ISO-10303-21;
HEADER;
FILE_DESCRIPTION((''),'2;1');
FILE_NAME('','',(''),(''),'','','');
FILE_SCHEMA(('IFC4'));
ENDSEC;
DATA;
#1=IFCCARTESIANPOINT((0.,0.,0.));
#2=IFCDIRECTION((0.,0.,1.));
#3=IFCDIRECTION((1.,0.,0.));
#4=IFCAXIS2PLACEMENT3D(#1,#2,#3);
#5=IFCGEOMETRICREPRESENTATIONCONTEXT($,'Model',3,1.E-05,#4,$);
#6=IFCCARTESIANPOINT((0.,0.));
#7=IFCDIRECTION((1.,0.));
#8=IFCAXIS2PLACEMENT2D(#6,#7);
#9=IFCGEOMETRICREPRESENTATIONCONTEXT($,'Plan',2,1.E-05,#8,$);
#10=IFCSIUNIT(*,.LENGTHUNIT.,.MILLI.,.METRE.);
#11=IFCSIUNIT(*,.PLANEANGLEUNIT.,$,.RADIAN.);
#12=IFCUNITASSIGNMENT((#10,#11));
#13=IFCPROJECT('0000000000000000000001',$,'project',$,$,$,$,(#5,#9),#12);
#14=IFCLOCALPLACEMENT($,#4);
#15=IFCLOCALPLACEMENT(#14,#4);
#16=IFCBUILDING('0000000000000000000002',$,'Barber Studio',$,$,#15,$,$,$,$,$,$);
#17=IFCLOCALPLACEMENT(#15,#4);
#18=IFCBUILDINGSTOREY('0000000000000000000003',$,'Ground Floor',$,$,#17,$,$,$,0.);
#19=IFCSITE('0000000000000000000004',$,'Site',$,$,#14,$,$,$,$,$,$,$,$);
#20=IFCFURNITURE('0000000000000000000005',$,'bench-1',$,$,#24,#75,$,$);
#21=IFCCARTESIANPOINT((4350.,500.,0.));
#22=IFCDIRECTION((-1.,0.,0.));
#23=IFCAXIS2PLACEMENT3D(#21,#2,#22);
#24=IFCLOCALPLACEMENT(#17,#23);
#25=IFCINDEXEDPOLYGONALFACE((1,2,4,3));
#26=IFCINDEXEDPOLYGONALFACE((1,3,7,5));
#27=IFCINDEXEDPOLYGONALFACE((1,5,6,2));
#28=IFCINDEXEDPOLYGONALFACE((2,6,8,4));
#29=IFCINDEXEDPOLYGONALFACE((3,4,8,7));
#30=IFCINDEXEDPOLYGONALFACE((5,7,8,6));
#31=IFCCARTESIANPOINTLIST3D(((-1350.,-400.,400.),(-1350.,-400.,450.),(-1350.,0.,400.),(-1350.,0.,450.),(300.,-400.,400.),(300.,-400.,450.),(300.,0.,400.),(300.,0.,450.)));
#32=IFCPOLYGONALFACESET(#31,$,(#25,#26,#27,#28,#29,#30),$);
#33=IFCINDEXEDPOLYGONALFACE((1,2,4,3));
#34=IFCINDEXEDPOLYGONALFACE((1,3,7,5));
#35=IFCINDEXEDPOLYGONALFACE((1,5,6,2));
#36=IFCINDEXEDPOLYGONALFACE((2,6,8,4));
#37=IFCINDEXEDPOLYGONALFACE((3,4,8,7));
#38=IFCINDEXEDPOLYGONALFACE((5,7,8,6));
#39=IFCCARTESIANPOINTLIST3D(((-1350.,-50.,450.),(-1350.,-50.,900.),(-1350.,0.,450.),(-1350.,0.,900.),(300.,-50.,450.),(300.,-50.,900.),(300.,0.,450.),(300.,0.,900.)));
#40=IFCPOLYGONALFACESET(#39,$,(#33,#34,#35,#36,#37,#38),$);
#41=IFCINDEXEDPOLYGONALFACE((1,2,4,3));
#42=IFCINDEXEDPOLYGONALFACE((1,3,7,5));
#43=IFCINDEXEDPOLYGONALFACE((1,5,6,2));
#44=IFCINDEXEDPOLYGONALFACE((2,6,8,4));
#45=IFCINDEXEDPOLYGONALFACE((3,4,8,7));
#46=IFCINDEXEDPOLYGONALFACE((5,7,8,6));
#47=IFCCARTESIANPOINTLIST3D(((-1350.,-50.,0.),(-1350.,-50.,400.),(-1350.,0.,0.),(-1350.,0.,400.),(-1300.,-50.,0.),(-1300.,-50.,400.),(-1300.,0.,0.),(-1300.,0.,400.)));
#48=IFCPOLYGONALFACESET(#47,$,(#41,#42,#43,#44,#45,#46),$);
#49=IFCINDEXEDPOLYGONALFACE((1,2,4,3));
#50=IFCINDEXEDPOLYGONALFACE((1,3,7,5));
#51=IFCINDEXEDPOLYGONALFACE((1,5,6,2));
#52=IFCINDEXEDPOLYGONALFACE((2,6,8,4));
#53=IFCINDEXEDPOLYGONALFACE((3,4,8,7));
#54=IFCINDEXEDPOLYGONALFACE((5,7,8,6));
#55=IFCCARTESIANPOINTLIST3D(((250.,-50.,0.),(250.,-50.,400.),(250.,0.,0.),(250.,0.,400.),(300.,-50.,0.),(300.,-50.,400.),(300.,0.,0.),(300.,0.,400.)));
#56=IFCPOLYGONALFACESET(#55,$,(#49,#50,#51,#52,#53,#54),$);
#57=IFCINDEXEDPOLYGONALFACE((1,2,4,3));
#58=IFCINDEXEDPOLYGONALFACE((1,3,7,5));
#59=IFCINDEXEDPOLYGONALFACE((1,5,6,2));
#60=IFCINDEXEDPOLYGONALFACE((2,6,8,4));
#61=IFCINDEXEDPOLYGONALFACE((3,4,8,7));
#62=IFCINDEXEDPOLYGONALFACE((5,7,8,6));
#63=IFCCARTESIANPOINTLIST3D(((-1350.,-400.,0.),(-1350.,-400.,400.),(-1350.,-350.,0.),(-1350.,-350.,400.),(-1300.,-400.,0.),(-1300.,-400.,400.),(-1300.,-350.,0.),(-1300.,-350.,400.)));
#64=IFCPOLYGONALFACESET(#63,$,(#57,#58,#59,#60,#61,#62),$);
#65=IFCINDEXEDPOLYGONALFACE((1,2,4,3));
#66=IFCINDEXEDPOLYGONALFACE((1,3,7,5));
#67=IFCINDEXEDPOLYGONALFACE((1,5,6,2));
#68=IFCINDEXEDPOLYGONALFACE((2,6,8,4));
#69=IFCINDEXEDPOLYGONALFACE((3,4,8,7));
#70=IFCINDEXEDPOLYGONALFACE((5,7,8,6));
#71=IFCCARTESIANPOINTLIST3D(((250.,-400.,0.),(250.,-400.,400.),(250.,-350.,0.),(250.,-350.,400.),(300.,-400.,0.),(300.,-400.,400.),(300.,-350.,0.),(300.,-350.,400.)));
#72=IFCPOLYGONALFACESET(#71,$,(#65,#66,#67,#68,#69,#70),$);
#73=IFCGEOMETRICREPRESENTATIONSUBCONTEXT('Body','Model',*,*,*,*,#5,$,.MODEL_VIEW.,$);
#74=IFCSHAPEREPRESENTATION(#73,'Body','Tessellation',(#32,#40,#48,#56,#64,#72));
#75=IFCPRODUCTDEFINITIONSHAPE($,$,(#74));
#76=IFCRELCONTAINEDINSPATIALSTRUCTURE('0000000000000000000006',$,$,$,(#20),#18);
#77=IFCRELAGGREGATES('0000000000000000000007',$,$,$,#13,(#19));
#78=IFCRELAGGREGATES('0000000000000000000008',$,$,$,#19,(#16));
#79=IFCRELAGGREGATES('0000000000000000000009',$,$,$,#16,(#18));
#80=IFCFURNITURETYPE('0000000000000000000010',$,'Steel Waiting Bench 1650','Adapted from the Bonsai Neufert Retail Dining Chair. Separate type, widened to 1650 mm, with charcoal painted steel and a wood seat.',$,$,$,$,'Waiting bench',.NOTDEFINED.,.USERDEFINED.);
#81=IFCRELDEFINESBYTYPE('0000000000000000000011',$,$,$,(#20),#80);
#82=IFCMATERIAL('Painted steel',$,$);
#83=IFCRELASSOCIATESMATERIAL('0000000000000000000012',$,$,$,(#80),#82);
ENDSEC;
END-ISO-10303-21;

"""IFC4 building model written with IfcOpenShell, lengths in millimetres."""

from ifc_helpers import new_model, entity, si_unit, frame, origin_with_axes, origin_2d_with_axis, place, context, subcontext, project, spatial, line, indexed_curve, outline, extrude, shape, source, transform, mapped, material, type_object, type_shapes, element, save


model = new_model("IFC4")

# Units and contexts
model_context = context("Model", 3, precision=1e-05, world=origin_with_axes())
plan_context = context("Plan", 2, precision=1e-05, world=origin_2d_with_axis())
body_context_1 = subcontext(model_context, "Body", "Model", "MODEL_VIEW")
body_context_2 = subcontext(plan_context, "Body", "Plan", "PLAN_VIEW")
ifc_project = project(units=[si_unit("LENGTHUNIT", "METRE", prefix="MILLI"), si_unit("PLANEANGLEUNIT", "RADIAN")], contexts=[model_context, plan_context])

# Site, building, storey
site_placement = place(None, origin_with_axes())
site = spatial("IfcSite", under=ifc_project, at=site_placement, Name="Site")
building_placement = place(site_placement, origin_with_axes())
building = spatial("IfcBuilding", under=site, at=building_placement, Name="Barber Studio")
storey_placement = place(building_placement, origin_with_axes())
storey = spatial("IfcBuildingStorey", under=building, at=storey_placement, Name="Ground Floor", Elevation=0.0)

# Shared definitions
ifc_material_1 = material(Name="Painted steel")

# Furniture
furniture_type_1 = type_object("IfcFurnitureType", Name="Steel Waiting Bench 1650", Description="Adapted from the Bonsai Neufert Retail Dining Chair. Separate type, widened to 1650 mm, with charcoal painted steel and a wood seat.", ElementType="Waiting bench", AssemblyPlace="NOTDEFINED", PredefinedType="USERDEFINED", material=ifc_material_1)
shared_shape_1 = source(origin_with_axes(), body_context_1, "Body", "SweptSolid", [
    extrude(outline(indexed_curve([(-1350.0, 0.0), (300.0, 0.0), (300.0, -400.0), (-1350.0, -400.0)], segments=[line(1, 2, 3, 4, 1)])), frame((0.0, 0.0, 450.0), z_axis=(0.0, 0.0, 1.0), x_axis=(1.0, 0.0, 0.0)), (0.0, 0.0, -1.0), 50.0),
    extrude(outline(indexed_curve([(-1350.0, 0.0), (300.0, 0.0), (300.0, -50.0), (-1350.0, -50.0)], segments=[line(1, 2, 3, 4, 1)])), frame((0.0, 0.0, 900.0), z_axis=(0.0, 0.0, 1.0), x_axis=(1.0, 0.0, 0.0)), (0.0, 0.0, -1.0), 450.0),
    extrude(outline(indexed_curve([(-1350.0, 0.0), (-1300.0, 0.0), (-1300.0, -50.0), (-1350.0, -50.0)], segments=[line(1, 2, 3, 4, 1)])), origin_with_axes(), (0.0, 0.0, 1.0), 400.0),
    extrude(outline(indexed_curve([(300.0, 0.0), (250.0, 0.0), (250.0, -50.0), (300.0, -50.0)], segments=[line(1, 2, 3, 4, 1)])), origin_with_axes(), (0.0, 0.0, 1.0), 400.0),
    extrude(outline(indexed_curve([(-1350.0, -400.0), (-1300.0, -400.0), (-1300.0, -350.0), (-1350.0, -350.0)], segments=[line(1, 2, 3, 4, 1)])), origin_with_axes(), (0.0, 0.0, 1.0), 400.0),
    extrude(outline(indexed_curve([(300.0, -400.0), (250.0, -400.0), (250.0, -350.0), (300.0, -350.0)], segments=[line(1, 2, 3, 4, 1)])), origin_with_axes(), (0.0, 0.0, 1.0), 400.0),
])
shared_shape_2 = source(origin_with_axes(), body_context_2, "Body", "Curve2D", [
    entity("IfcIndexedPolyCurve", entity("IfcCartesianPointList2D", [[-1350.0, -400.0], [300.0, -400.0]])),
    entity("IfcIndexedPolyCurve", entity("IfcCartesianPointList2D", [[-1350.0, -400.0], [-1350.0, -300.0], [-212.1, -87.9], [0.0, 0.0], [212.1, -87.9], [300.0, -300.0], [300.0, -400.0]]), [entity("IfcLineIndex", [1, 2]), entity("IfcArcIndex", [2, 3, 4]), entity("IfcArcIndex", [4, 5, 6]), entity("IfcLineIndex", [6, 7])]),
    entity("IfcIndexedPolyCurve", entity("IfcCartesianPointList2D", [[-260.0, -400.0], [-260.0, -300.0], [-183.8, -116.2], [0.0, -40.0], [183.8, -116.2], [260.0, -300.0], [260.0, -400.0]]), [entity("IfcLineIndex", [1, 2]), entity("IfcArcIndex", [2, 3, 4]), entity("IfcArcIndex", [4, 5, 6]), entity("IfcLineIndex", [6, 7])]),
])
type_shapes(furniture_type_1, [shared_shape_1, shared_shape_2])
furniture_1_placement = place(storey_placement, frame((4350.0, 500.0, 0.0), z_axis=(0.0, 0.0, 1.0), x_axis=(-1.0, 0.0, 0.0)))
element("IfcFurniture", 1, at=furniture_1_placement, inside=storey, type_object=furniture_type_1, Name="bench-1", shapes=[
    shape(body_context_1, "Body", "MappedRepresentation", [mapped(shared_shape_1, transform((0.0, 0.0, 0.0), x_axis=(1.0, 0.0, 0.0), y_axis=(0.0, 1.0, 0.0), z_axis=(0.0, 0.0, 1.0), scale=1.0))]),
    shape(body_context_2, "Body", "MappedRepresentation", [mapped(shared_shape_2, transform((0.0, 0.0, 0.0), x_axis=(1.0, 0.0, 0.0), y_axis=(0.0, 1.0, 0.0), z_axis=(0.0, 0.0, 1.0), scale=1.0))]),
])

save(model, "model.ifc")
